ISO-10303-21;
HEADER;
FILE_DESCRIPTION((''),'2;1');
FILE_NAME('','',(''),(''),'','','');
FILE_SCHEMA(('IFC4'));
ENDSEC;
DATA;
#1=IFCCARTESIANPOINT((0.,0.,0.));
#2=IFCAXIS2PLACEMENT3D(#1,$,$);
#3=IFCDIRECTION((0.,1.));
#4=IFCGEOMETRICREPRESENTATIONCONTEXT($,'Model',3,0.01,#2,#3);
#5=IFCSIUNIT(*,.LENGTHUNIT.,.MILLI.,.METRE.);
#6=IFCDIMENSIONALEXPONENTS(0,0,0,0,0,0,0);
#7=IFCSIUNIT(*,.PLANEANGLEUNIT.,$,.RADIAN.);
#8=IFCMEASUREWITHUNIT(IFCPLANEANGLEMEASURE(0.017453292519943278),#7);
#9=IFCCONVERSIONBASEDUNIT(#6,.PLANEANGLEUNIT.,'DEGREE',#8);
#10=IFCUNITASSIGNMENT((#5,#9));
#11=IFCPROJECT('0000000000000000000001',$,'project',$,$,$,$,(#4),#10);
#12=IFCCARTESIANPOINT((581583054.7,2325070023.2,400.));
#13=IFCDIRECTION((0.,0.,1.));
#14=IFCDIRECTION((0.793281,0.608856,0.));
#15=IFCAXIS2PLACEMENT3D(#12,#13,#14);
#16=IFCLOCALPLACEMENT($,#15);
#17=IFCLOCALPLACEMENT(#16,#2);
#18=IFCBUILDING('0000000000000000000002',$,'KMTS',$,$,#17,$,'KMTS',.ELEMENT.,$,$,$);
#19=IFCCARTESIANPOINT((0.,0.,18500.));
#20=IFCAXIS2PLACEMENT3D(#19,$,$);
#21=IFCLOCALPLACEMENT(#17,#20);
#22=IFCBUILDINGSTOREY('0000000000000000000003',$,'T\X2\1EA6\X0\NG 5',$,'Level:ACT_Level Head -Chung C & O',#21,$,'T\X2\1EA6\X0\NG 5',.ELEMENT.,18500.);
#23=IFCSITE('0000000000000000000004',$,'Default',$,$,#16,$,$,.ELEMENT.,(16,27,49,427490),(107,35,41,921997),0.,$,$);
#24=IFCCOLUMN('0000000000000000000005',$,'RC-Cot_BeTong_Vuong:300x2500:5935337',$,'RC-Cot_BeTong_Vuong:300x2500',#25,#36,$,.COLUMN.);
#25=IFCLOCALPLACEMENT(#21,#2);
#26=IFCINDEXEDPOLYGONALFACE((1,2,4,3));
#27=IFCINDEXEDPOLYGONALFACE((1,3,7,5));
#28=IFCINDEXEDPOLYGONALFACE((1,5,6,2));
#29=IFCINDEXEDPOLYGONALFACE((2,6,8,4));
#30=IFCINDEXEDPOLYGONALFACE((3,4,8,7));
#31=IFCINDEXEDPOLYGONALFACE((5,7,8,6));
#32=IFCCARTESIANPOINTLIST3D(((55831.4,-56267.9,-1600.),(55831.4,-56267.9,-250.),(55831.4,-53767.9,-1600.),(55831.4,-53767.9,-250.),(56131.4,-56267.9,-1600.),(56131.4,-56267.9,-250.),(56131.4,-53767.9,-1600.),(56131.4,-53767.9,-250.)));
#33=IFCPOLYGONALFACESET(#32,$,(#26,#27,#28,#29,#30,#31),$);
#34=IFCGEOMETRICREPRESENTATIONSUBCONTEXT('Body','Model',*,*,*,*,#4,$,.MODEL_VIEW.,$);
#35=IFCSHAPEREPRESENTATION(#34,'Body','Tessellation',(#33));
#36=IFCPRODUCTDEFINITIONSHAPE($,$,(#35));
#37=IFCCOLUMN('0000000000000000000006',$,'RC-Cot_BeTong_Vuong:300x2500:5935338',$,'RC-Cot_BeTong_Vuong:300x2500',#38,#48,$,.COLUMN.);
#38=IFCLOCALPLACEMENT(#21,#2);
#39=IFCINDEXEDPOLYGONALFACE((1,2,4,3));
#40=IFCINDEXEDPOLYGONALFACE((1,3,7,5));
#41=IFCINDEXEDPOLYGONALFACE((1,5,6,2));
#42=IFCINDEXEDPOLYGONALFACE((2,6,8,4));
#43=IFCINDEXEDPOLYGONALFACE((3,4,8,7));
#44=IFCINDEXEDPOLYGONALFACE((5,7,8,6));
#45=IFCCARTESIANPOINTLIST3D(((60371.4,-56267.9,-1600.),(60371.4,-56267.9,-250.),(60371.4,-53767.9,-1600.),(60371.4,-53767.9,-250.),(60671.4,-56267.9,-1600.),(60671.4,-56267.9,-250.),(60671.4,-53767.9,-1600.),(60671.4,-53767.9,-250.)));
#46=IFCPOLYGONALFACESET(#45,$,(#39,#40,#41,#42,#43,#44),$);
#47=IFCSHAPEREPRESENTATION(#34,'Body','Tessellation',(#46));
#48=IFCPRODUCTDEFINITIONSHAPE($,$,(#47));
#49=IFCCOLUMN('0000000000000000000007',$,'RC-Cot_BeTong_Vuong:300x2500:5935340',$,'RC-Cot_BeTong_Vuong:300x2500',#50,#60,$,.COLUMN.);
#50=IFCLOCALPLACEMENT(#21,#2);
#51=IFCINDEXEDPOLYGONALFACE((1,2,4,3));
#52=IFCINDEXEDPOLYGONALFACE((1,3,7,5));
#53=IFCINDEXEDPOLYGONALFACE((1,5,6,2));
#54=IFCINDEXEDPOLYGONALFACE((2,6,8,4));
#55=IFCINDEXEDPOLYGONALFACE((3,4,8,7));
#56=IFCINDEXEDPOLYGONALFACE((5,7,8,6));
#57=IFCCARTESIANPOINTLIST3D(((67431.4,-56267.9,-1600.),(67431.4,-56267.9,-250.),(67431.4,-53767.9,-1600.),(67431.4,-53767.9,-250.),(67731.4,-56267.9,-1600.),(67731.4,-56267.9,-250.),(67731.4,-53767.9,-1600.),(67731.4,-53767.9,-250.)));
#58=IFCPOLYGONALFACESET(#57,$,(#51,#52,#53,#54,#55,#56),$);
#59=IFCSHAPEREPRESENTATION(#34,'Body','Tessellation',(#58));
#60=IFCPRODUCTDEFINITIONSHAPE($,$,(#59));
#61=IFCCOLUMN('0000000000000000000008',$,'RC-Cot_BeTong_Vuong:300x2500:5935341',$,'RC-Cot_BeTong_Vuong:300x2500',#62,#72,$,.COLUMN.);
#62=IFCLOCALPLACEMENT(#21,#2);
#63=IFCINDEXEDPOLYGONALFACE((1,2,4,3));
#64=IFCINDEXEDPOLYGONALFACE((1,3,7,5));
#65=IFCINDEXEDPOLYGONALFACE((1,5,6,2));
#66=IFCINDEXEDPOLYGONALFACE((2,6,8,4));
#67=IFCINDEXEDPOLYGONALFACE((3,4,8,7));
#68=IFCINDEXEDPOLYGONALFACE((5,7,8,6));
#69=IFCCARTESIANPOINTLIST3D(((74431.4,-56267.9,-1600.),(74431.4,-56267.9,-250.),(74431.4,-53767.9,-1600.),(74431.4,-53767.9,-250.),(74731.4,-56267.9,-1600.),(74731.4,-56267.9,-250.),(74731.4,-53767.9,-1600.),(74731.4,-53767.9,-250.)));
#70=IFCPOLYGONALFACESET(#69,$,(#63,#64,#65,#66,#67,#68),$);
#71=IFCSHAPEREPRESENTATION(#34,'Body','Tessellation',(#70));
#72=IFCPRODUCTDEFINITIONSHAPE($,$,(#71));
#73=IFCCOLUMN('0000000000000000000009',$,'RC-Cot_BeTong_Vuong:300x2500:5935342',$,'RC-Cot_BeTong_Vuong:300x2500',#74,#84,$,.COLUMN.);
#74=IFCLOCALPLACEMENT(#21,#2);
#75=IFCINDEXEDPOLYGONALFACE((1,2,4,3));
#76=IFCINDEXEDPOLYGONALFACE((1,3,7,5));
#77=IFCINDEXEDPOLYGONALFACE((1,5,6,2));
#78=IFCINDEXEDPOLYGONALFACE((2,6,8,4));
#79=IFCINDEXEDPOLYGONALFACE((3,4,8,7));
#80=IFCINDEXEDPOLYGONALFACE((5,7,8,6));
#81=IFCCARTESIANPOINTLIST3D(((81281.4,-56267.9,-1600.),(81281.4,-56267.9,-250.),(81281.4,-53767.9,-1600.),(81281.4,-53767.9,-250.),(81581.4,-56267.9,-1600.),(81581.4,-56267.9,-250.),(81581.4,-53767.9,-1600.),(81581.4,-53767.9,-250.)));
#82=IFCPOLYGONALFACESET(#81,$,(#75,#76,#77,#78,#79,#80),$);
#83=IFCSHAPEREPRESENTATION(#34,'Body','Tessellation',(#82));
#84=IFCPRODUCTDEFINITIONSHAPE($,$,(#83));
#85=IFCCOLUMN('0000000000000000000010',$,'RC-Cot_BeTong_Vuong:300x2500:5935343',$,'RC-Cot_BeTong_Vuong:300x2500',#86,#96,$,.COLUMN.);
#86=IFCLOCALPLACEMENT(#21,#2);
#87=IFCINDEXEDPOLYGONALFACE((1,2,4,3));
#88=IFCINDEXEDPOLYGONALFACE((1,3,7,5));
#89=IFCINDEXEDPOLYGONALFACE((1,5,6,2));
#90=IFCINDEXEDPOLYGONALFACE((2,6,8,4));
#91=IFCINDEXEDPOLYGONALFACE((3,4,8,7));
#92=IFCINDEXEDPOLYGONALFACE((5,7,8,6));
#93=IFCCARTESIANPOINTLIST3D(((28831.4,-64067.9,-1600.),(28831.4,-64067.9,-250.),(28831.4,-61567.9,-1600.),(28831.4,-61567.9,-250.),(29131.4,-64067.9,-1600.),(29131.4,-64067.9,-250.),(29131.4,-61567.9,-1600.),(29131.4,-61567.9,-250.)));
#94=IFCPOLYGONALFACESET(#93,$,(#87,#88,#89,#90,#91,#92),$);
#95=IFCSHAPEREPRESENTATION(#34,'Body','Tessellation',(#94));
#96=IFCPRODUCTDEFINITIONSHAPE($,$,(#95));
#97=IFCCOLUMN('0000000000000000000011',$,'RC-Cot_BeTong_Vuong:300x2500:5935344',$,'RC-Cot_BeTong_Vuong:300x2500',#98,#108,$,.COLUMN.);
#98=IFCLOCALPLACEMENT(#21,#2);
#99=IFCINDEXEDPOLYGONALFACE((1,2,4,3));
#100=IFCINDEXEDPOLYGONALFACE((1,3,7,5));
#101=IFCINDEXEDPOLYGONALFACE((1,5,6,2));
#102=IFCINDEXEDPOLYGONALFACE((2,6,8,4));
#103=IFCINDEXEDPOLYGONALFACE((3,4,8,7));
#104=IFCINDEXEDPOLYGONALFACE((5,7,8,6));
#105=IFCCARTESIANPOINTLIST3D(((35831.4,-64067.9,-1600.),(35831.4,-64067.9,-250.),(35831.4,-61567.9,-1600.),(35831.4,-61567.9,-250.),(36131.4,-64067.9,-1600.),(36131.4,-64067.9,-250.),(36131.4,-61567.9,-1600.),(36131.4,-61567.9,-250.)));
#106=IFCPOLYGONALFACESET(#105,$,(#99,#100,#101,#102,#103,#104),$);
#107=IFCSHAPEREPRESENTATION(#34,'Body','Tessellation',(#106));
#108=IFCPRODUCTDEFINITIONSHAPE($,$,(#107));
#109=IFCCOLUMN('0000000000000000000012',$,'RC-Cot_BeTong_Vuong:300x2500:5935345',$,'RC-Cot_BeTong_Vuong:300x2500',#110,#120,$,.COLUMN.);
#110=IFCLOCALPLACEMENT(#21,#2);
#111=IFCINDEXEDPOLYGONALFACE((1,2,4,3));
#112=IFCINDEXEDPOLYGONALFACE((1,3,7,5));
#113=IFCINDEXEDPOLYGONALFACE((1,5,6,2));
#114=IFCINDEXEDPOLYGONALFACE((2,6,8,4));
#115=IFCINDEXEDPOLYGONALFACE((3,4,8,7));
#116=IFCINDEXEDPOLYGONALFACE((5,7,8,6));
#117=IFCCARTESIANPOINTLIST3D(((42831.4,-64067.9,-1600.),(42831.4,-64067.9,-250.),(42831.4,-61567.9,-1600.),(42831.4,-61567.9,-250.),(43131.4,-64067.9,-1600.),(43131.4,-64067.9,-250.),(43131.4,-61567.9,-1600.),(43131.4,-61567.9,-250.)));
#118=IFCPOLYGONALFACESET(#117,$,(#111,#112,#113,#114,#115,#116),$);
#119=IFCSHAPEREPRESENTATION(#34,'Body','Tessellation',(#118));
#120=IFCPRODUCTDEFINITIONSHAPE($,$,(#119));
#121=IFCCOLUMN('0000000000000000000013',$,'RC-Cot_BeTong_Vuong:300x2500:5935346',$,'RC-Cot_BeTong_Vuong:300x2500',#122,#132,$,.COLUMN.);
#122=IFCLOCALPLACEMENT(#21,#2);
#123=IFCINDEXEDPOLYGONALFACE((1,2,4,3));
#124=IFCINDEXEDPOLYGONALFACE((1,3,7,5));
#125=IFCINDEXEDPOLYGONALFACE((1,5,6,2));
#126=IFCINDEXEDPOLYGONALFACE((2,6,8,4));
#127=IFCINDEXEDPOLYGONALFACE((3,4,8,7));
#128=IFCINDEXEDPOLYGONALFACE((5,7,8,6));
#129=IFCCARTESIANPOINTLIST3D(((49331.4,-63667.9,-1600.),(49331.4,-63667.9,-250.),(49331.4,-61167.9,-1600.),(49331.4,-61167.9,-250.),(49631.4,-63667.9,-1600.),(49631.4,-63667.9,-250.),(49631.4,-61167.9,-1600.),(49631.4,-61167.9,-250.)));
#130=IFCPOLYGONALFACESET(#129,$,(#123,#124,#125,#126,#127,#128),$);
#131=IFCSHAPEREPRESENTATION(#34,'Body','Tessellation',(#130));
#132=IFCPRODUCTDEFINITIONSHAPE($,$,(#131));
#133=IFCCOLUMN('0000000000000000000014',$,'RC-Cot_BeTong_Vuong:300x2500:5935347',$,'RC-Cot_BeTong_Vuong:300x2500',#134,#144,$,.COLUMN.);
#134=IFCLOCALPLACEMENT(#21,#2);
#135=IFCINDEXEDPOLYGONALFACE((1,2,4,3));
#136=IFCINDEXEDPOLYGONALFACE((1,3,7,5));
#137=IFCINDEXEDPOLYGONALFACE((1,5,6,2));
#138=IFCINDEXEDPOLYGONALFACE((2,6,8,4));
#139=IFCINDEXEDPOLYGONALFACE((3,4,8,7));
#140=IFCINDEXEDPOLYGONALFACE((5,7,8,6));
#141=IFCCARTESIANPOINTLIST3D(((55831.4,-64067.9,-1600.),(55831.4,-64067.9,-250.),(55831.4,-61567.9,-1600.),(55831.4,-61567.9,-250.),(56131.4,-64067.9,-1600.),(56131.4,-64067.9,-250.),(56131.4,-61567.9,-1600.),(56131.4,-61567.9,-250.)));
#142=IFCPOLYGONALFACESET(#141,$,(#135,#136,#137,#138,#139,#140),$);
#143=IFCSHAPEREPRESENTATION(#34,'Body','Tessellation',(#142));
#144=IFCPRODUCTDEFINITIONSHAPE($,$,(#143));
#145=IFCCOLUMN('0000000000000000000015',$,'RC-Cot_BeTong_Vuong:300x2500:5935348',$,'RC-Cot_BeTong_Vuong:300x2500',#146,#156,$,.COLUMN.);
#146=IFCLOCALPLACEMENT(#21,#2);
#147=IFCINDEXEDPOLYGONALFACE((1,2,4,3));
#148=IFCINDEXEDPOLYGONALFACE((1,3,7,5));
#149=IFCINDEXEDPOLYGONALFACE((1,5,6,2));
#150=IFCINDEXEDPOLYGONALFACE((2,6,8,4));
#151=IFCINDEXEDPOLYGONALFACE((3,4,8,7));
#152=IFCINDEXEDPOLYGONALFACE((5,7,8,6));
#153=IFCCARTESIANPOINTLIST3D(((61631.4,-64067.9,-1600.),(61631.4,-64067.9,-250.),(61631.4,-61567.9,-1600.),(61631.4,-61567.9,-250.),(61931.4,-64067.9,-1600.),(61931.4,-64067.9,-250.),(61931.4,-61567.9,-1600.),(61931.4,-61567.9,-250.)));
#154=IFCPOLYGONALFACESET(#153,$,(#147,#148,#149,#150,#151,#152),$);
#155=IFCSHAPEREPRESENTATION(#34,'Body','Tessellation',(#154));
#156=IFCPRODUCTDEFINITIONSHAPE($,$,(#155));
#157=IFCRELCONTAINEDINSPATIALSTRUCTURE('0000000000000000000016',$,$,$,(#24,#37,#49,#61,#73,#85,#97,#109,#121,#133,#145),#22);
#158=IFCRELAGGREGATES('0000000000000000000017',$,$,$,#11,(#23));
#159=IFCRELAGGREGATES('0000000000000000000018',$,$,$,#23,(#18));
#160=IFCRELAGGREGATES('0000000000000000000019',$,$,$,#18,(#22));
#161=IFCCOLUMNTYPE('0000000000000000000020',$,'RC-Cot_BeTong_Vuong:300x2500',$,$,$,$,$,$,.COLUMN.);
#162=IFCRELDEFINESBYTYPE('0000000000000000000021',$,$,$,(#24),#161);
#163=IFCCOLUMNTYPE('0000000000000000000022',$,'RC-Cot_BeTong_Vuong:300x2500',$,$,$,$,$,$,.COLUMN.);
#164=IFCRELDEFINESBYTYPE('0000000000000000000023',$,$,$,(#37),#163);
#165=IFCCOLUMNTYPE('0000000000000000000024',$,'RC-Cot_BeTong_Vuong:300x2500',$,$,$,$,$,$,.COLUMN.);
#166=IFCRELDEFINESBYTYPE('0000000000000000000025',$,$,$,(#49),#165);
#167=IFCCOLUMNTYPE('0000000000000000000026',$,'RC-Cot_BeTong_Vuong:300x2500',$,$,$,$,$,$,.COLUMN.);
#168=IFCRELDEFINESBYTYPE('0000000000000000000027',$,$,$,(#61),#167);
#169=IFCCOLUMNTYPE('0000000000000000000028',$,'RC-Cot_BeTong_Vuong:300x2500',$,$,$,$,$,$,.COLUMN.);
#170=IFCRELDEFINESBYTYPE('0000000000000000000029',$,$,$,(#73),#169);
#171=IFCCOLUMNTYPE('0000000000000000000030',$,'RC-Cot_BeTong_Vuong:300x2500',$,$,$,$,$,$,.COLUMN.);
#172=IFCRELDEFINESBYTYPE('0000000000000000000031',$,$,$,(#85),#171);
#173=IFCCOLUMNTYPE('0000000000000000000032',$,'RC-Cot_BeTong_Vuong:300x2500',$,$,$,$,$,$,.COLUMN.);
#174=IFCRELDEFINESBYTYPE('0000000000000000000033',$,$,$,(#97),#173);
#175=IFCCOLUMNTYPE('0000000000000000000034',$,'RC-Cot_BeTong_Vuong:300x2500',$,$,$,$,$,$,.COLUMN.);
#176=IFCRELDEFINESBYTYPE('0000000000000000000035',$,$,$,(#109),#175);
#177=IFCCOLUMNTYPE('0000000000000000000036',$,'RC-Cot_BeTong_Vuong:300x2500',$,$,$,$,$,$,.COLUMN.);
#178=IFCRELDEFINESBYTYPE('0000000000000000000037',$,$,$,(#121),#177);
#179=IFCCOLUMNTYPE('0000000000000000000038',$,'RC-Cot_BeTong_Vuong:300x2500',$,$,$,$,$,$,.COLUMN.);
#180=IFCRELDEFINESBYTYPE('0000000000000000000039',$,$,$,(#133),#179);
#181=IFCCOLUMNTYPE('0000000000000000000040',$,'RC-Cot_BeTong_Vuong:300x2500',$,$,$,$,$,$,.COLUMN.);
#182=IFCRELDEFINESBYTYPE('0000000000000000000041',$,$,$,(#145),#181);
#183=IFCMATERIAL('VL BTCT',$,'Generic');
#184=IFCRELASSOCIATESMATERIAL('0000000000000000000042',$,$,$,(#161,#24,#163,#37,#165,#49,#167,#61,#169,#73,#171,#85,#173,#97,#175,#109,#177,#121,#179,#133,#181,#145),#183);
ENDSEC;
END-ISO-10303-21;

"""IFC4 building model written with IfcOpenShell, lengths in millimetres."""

from ifc_helpers import new_model, entity, si_unit, converted_unit, direction, frame, origin, place, context, subcontext, project, spatial, indexed_curve, outline, extrude, source, transform, mapped, material, type_object, type_shapes, element, save


model = new_model("IFC4")

# Units and contexts
model_context = context("Model", 3, precision=0.01, world=origin(), true_north=direction((0.0, 1.0)))
body_context = subcontext(model_context, "Body", "Model", "MODEL_VIEW")
ifc_project = project(units=[si_unit("LENGTHUNIT", "METRE", prefix="MILLI"), converted_unit("PLANEANGLEUNIT", "DEGREE", entity("IfcPlaneAngleMeasure", 0.017453292519943278), si_unit("PLANEANGLEUNIT", "RADIAN"), dimensions=[0, 0, 0, 0, 0, 0, 0])], contexts=[model_context])

# Site, building, storey
site_placement = place(None, frame((581583054.7, 2325070023.2, 400.0), z_axis=(0.0, 0.0, 1.0), x_axis=(0.793281, 0.608856, 0.0)))
site = spatial("IfcSite", under=ifc_project, at=site_placement, Name="Default", CompositionType="ELEMENT", RefLatitude=(16, 27, 49, 427490), RefLongitude=(107, 35, 41, 921997), RefElevation=0.0)
building_placement = place(site_placement, origin())
building = spatial("IfcBuilding", under=site, at=building_placement, Name="KMTS", LongName="KMTS", CompositionType="ELEMENT")
storey_placement = place(building_placement, frame((0.0, 0.0, 18500.0)))
storey = spatial("IfcBuildingStorey", under=building, at=storey_placement, Name="TẦNG 5", ObjectType="Level:ACT_Level Head -Chung C & O", LongName="TẦNG 5", CompositionType="ELEMENT", Elevation=18500.0)

# Columns
ifc_material_1 = material(Name="VL BTCT", Category="Generic")
column_type_1 = type_object("IfcColumnType", Name="RC-Cot_BeTong_Vuong:300x2500", PredefinedType="COLUMN", material=ifc_material_1)
shared_shape_1 = source(origin(), body_context, "Body", "SweptSolid", [
    extrude(outline(indexed_curve([(-675.0, -1250.0), (675.0, -1250.0), (675.0, 1250.0), (-675.0, 1250.0), (-675.0, -1250.0)], self_intersect=False)), frame((55831.4, -55017.9, 17575.0), z_axis=(1.0, 0.0, 0.0), x_axis=(0.0, 0.0, 1.0)), (0.0, 0.0, 1.0), 300.0),
])
type_shapes(column_type_1, [shared_shape_1])
column_1_placement = place(storey_placement, frame((0.0, 0.0, -18500.0)))
element("IfcColumn", 1, at=column_1_placement, inside=storey, type_object=column_type_1, material=ifc_material_1, Name="RC-Cot_BeTong_Vuong:300x2500:5935337", ObjectType="RC-Cot_BeTong_Vuong:300x2500", PredefinedType="COLUMN", context=body_context, shape_type="MappedRepresentation", body=[
    mapped(shared_shape_1, transform((0.0, 0.0, 0.0), scale=1.0)),
])
column_type_2 = type_object("IfcColumnType", Name="RC-Cot_BeTong_Vuong:300x2500", PredefinedType="COLUMN", material=ifc_material_1)
shared_shape_2 = source(origin(), body_context, "Body", "SweptSolid", [
    extrude(outline(indexed_curve([(-675.0, -1250.0), (675.0, -1250.0), (675.0, 1250.0), (-675.0, 1250.0), (-675.0, -1250.0)], self_intersect=False)), frame((60371.4, -55017.9, 17575.0), z_axis=(1.0, 0.0, 0.0), x_axis=(0.0, 0.0, 1.0)), (0.0, 0.0, 1.0), 300.0),
])
type_shapes(column_type_2, [shared_shape_2])
column_2_placement = place(storey_placement, frame((0.0, 0.0, -18500.0)))
element("IfcColumn", 2, at=column_2_placement, inside=storey, type_object=column_type_2, material=ifc_material_1, Name="RC-Cot_BeTong_Vuong:300x2500:5935338", ObjectType="RC-Cot_BeTong_Vuong:300x2500", PredefinedType="COLUMN", context=body_context, shape_type="MappedRepresentation", body=[
    mapped(shared_shape_2, transform((0.0, 0.0, 0.0), scale=1.0)),
])
column_type_3 = type_object("IfcColumnType", Name="RC-Cot_BeTong_Vuong:300x2500", PredefinedType="COLUMN", material=ifc_material_1)
shared_shape_3 = source(origin(), body_context, "Body", "SweptSolid", [
    extrude(outline(indexed_curve([(-675.0, -1250.0), (675.0, -1250.0), (675.0, 1250.0), (-675.0, 1250.0), (-675.0, -1250.0)], self_intersect=False)), frame((67431.4, -55017.9, 17575.0), z_axis=(1.0, 0.0, 0.0), x_axis=(0.0, 0.0, 1.0)), (0.0, 0.0, 1.0), 300.0),
])
type_shapes(column_type_3, [shared_shape_3])
column_3_placement = place(storey_placement, frame((0.0, 0.0, -18500.0)))
element("IfcColumn", 3, at=column_3_placement, inside=storey, type_object=column_type_3, material=ifc_material_1, Name="RC-Cot_BeTong_Vuong:300x2500:5935340", ObjectType="RC-Cot_BeTong_Vuong:300x2500", PredefinedType="COLUMN", context=body_context, shape_type="MappedRepresentation", body=[
    mapped(shared_shape_3, transform((0.0, 0.0, 0.0), scale=1.0)),
])
column_type_4 = type_object("IfcColumnType", Name="RC-Cot_BeTong_Vuong:300x2500", PredefinedType="COLUMN", material=ifc_material_1)
shared_shape_4 = source(origin(), body_context, "Body", "SweptSolid", [
    extrude(outline(indexed_curve([(-675.0, -1250.0), (675.0, -1250.0), (675.0, 1250.0), (-675.0, 1250.0), (-675.0, -1250.0)], self_intersect=False)), frame((74431.4, -55017.9, 17575.0), z_axis=(1.0, 0.0, 0.0), x_axis=(0.0, 0.0, 1.0)), (0.0, 0.0, 1.0), 300.0),
])
type_shapes(column_type_4, [shared_shape_4])
column_4_placement = place(storey_placement, frame((0.0, 0.0, -18500.0)))
element("IfcColumn", 4, at=column_4_placement, inside=storey, type_object=column_type_4, material=ifc_material_1, Name="RC-Cot_BeTong_Vuong:300x2500:5935341", ObjectType="RC-Cot_BeTong_Vuong:300x2500", PredefinedType="COLUMN", context=body_context, shape_type="MappedRepresentation", body=[
    mapped(shared_shape_4, transform((0.0, 0.0, 0.0), scale=1.0)),
])
column_type_5 = type_object("IfcColumnType", Name="RC-Cot_BeTong_Vuong:300x2500", PredefinedType="COLUMN", material=ifc_material_1)
shared_shape_5 = source(origin(), body_context, "Body", "SweptSolid", [
    extrude(outline(indexed_curve([(-675.0, -1250.0), (675.0, -1250.0), (675.0, 1250.0), (-675.0, 1250.0), (-675.0, -1250.0)], self_intersect=False)), frame((81281.4, -55017.9, 17575.0), z_axis=(1.0, 0.0, 0.0), x_axis=(0.0, 0.0, 1.0)), (0.0, 0.0, 1.0), 300.0),
])
type_shapes(column_type_5, [shared_shape_5])
column_5_placement = place(storey_placement, frame((0.0, 0.0, -18500.0)))
element("IfcColumn", 5, at=column_5_placement, inside=storey, type_object=column_type_5, material=ifc_material_1, Name="RC-Cot_BeTong_Vuong:300x2500:5935342", ObjectType="RC-Cot_BeTong_Vuong:300x2500", PredefinedType="COLUMN", context=body_context, shape_type="MappedRepresentation", body=[
    mapped(shared_shape_5, transform((0.0, 0.0, 0.0), scale=1.0)),
])
column_type_6 = type_object("IfcColumnType", Name="RC-Cot_BeTong_Vuong:300x2500", PredefinedType="COLUMN", material=ifc_material_1)
shared_shape_6 = source(origin(), body_context, "Body", "SweptSolid", [
    extrude(outline(indexed_curve([(-675.0, -1250.0), (675.0, -1250.0), (675.0, 1250.0), (-675.0, 1250.0), (-675.0, -1250.0)], self_intersect=False)), frame((28831.4, -62817.9, 17575.0), z_axis=(1.0, 0.0, 0.0), x_axis=(0.0, 0.0, 1.0)), (0.0, 0.0, 1.0), 300.0),
])
type_shapes(column_type_6, [shared_shape_6])
column_6_placement = place(storey_placement, frame((0.0, 0.0, -18500.0)))
element("IfcColumn", 6, at=column_6_placement, inside=storey, type_object=column_type_6, material=ifc_material_1, Name="RC-Cot_BeTong_Vuong:300x2500:5935343", ObjectType="RC-Cot_BeTong_Vuong:300x2500", PredefinedType="COLUMN", context=body_context, shape_type="MappedRepresentation", body=[
    mapped(shared_shape_6, transform((0.0, 0.0, 0.0), scale=1.0)),
])
column_type_7 = type_object("IfcColumnType", Name="RC-Cot_BeTong_Vuong:300x2500", PredefinedType="COLUMN", material=ifc_material_1)
shared_shape_7 = source(origin(), body_context, "Body", "SweptSolid", [
    extrude(outline(indexed_curve([(-675.0, -1250.0), (675.0, -1250.0), (675.0, 1250.0), (-675.0, 1250.0), (-675.0, -1250.0)], self_intersect=False)), frame((35831.4, -62817.9, 17575.0), z_axis=(1.0, 0.0, 0.0), x_axis=(0.0, 0.0, 1.0)), (0.0, 0.0, 1.0), 300.0),
])
type_shapes(column_type_7, [shared_shape_7])
column_7_placement = place(storey_placement, frame((0.0, 0.0, -18500.0)))
element("IfcColumn", 7, at=column_7_placement, inside=storey, type_object=column_type_7, material=ifc_material_1, Name="RC-Cot_BeTong_Vuong:300x2500:5935344", ObjectType="RC-Cot_BeTong_Vuong:300x2500", PredefinedType="COLUMN", context=body_context, shape_type="MappedRepresentation", body=[
    mapped(shared_shape_7, transform((0.0, 0.0, 0.0), scale=1.0)),
])
column_type_8 = type_object("IfcColumnType", Name="RC-Cot_BeTong_Vuong:300x2500", PredefinedType="COLUMN", material=ifc_material_1)
shared_shape_8 = source(origin(), body_context, "Body", "SweptSolid", [
    extrude(outline(indexed_curve([(-675.0, -1250.0), (675.0, -1250.0), (675.0, 1250.0), (-675.0, 1250.0), (-675.0, -1250.0)], self_intersect=False)), frame((42831.4, -62817.9, 17575.0), z_axis=(1.0, 0.0, 0.0), x_axis=(0.0, 0.0, 1.0)), (0.0, 0.0, 1.0), 300.0),
])
type_shapes(column_type_8, [shared_shape_8])
column_8_placement = place(storey_placement, frame((0.0, 0.0, -18500.0)))
element("IfcColumn", 8, at=column_8_placement, inside=storey, type_object=column_type_8, material=ifc_material_1, Name="RC-Cot_BeTong_Vuong:300x2500:5935345", ObjectType="RC-Cot_BeTong_Vuong:300x2500", PredefinedType="COLUMN", context=body_context, shape_type="MappedRepresentation", body=[
    mapped(shared_shape_8, transform((0.0, 0.0, 0.0), scale=1.0)),
])
column_type_9 = type_object("IfcColumnType", Name="RC-Cot_BeTong_Vuong:300x2500", PredefinedType="COLUMN", material=ifc_material_1)
shared_shape_9 = source(origin(), body_context, "Body", "SweptSolid", [
    extrude(outline(indexed_curve([(-675.0, -1250.0), (675.0, -1250.0), (675.0, 1250.0), (-675.0, 1250.0), (-675.0, -1250.0)], self_intersect=False)), frame((49331.4, -62417.9, 17575.0), z_axis=(1.0, 0.0, 0.0), x_axis=(0.0, 0.0, 1.0)), (0.0, 0.0, 1.0), 300.0),
])
type_shapes(column_type_9, [shared_shape_9])
column_9_placement = place(storey_placement, frame((0.0, 0.0, -18500.0)))
element("IfcColumn", 9, at=column_9_placement, inside=storey, type_object=column_type_9, material=ifc_material_1, Name="RC-Cot_BeTong_Vuong:300x2500:5935346", ObjectType="RC-Cot_BeTong_Vuong:300x2500", PredefinedType="COLUMN", context=body_context, shape_type="MappedRepresentation", body=[
    mapped(shared_shape_9, transform((0.0, 0.0, 0.0), scale=1.0)),
])
column_type_10 = type_object("IfcColumnType", Name="RC-Cot_BeTong_Vuong:300x2500", PredefinedType="COLUMN", material=ifc_material_1)
shared_shape_10 = source(origin(), body_context, "Body", "SweptSolid", [
    extrude(outline(indexed_curve([(-675.0, -1250.0), (675.0, -1250.0), (675.0, 1250.0), (-675.0, 1250.0), (-675.0, -1250.0)], self_intersect=False)), frame((55831.4, -62817.9, 17575.0), z_axis=(1.0, 0.0, 0.0), x_axis=(0.0, 0.0, 1.0)), (0.0, 0.0, 1.0), 300.0),
])
type_shapes(column_type_10, [shared_shape_10])
column_10_placement = place(storey_placement, frame((0.0, 0.0, -18500.0)))
element("IfcColumn", 10, at=column_10_placement, inside=storey, type_object=column_type_10, material=ifc_material_1, Name="RC-Cot_BeTong_Vuong:300x2500:5935347", ObjectType="RC-Cot_BeTong_Vuong:300x2500", PredefinedType="COLUMN", context=body_context, shape_type="MappedRepresentation", body=[
    mapped(shared_shape_10, transform((0.0, 0.0, 0.0), scale=1.0)),
])
column_type_11 = type_object("IfcColumnType", Name="RC-Cot_BeTong_Vuong:300x2500", PredefinedType="COLUMN", material=ifc_material_1)
shared_shape_11 = source(origin(), body_context, "Body", "SweptSolid", [
    extrude(outline(indexed_curve([(-675.0, -1250.0), (675.0, -1250.0), (675.0, 1250.0), (-675.0, 1250.0), (-675.0, -1250.0)], self_intersect=False)), frame((61631.4, -62817.9, 17575.0), z_axis=(1.0, 0.0, 0.0), x_axis=(0.0, 0.0, 1.0)), (0.0, 0.0, 1.0), 300.0),
])
type_shapes(column_type_11, [shared_shape_11])
column_11_placement = place(storey_placement, frame((0.0, 0.0, -18500.0)))
element("IfcColumn", 11, at=column_11_placement, inside=storey, type_object=column_type_11, material=ifc_material_1, Name="RC-Cot_BeTong_Vuong:300x2500:5935348", ObjectType="RC-Cot_BeTong_Vuong:300x2500", PredefinedType="COLUMN", context=body_context, shape_type="MappedRepresentation", body=[
    mapped(shared_shape_11, transform((0.0, 0.0, 0.0), scale=1.0)),
])

save(model, "model.ifc")
